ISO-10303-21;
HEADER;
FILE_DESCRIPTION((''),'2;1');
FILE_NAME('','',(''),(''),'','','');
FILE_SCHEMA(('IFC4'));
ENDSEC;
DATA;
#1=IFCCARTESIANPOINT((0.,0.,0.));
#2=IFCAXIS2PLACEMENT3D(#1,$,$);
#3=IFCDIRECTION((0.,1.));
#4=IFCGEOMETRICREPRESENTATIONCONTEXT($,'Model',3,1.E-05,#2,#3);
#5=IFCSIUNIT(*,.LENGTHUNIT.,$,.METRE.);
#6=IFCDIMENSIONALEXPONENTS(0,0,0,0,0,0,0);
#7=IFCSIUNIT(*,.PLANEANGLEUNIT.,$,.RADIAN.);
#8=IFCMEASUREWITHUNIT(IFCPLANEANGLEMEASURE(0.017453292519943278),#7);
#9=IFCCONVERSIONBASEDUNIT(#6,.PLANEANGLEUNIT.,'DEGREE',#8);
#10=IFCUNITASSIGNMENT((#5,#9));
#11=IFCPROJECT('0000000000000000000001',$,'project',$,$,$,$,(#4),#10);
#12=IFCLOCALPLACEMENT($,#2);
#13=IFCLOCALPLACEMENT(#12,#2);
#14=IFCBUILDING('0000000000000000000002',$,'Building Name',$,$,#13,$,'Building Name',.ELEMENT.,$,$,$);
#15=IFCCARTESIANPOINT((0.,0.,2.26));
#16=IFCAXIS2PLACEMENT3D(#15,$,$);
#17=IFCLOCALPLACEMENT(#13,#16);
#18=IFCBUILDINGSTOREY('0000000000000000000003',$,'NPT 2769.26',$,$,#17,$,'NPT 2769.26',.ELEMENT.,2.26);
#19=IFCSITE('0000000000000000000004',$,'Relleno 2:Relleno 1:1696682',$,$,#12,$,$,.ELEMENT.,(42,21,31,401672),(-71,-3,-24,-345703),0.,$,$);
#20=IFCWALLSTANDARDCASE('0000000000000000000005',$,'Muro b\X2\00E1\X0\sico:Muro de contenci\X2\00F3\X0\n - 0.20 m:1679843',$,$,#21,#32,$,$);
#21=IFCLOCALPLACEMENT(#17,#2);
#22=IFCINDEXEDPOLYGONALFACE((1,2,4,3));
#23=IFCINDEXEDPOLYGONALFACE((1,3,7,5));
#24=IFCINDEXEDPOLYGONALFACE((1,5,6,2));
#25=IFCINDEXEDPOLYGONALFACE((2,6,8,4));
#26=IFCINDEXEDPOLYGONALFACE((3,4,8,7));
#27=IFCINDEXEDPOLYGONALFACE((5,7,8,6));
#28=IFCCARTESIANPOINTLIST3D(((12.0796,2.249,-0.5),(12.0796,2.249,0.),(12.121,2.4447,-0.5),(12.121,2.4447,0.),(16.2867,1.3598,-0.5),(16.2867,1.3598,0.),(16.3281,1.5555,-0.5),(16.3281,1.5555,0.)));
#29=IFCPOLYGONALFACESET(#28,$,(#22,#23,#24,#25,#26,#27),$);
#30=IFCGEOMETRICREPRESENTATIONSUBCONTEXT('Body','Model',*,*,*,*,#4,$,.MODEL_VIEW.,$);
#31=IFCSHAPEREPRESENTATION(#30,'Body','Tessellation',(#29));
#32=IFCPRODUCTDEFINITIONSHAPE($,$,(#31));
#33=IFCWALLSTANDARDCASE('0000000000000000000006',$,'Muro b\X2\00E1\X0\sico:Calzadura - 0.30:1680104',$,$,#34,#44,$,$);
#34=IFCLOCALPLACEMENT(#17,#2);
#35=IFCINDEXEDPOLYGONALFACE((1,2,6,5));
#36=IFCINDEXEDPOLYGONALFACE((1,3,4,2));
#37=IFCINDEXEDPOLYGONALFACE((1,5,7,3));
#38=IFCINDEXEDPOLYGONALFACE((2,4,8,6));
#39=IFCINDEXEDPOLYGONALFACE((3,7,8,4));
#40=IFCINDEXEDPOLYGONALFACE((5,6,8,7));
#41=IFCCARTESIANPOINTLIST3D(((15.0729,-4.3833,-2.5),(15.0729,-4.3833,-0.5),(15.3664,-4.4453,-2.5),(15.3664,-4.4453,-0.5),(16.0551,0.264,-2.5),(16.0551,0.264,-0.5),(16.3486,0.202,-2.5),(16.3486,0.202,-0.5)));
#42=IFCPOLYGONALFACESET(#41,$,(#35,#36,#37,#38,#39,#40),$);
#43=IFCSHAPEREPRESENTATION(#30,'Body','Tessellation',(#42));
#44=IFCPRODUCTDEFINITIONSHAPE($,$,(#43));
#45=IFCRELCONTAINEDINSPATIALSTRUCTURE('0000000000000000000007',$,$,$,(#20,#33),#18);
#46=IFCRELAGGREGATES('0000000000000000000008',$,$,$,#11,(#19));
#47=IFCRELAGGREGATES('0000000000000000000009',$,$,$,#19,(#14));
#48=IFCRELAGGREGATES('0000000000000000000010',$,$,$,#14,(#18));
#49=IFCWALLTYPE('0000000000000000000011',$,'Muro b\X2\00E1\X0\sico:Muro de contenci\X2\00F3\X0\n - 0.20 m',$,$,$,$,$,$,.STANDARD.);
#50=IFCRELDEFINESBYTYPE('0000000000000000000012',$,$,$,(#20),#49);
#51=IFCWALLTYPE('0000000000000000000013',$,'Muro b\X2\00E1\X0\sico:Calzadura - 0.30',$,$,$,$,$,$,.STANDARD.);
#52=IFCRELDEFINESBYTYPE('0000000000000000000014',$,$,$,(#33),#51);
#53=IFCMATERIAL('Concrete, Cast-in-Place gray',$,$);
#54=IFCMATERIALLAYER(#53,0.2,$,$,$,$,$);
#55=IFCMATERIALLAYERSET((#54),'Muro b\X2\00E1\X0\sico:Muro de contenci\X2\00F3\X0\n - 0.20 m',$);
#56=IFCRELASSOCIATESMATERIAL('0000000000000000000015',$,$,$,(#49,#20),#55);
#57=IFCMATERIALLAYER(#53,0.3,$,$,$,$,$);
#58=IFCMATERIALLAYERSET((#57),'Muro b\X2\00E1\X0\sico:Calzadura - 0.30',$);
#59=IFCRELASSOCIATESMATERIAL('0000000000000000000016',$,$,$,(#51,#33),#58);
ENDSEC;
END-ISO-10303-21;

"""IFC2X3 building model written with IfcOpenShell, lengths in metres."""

from ifc_helpers import new_model, entity, si_unit, converted_unit, direction, frame, frame_2d, origin, place, context, subcontext, project, spatial, rectangle, extrude, material, layer, layer_set, layer_usage, type_object, element, save


model = new_model("IFC2X3")

# Units and contexts
model_context = context("Model", 3, precision=1e-05, world=origin(), true_north=direction((0.0, 1.0)))
body_context = subcontext(model_context, "Body", "Model", "MODEL_VIEW")
ifc_project = project(units=[si_unit("LENGTHUNIT", "METRE"), converted_unit("PLANEANGLEUNIT", "DEGREE", entity("IfcPlaneAngleMeasure", 0.017453292519943278), si_unit("PLANEANGLEUNIT", "RADIAN"), dimensions=[0, 0, 0, 0, 0, 0, 0])], contexts=[model_context])

# Site, building, storey
site_placement = place(None, origin())
site = spatial("IfcSite", under=ifc_project, at=site_placement, Name="Relleno 2:Relleno 1:1696682", CompositionType="ELEMENT", RefLatitude=(42, 21, 31, 401672), RefLongitude=(-71, -3, -24, -345703), RefElevation=0.0)
building_placement = place(site_placement, origin())
building = spatial("IfcBuilding", under=site, at=building_placement, Name="Building Name", LongName="Building Name", CompositionType="ELEMENT")
storey_placement = place(building_placement, frame((0.0, 0.0, 2.26)))
storey = spatial("IfcBuildingStorey", under=building, at=storey_placement, Name="NPT 2769.26", LongName="NPT 2769.26", CompositionType="ELEMENT", Elevation=2.26)

# Shared definitions
ifc_material = material(Name="Concrete, Cast-in-Place gray")

# Walls
ifc_layer_1 = layer(ifc_material, 0.2)
ifc_layer_set_1 = layer_set([ifc_layer_1], Name="Muro básico:Muro de contención - 0.20 m")
ifc_layer_usage_1 = layer_usage(ifc_layer_set_1, "AXIS2", "NEGATIVE", 0.1)
wall_type_1 = type_object("IfcWallType", Name="Muro básico:Muro de contención - 0.20 m", PredefinedType="STANDARD", material=ifc_layer_set_1)
wall_1_placement = place(storey_placement, frame((12.1003, 2.3468, -0.5), z_axis=(0.0, 0.0, 1.0), x_axis=(0.978388, -0.206778, 0.0)))
element("IfcWallStandardCase", 1, at=wall_1_placement, inside=storey, type_object=wall_type_1, material=ifc_layer_usage_1, Name="Muro básico:Muro de contención - 0.20 m:1679843", context=body_context, shape_type="SweptSolid", body=[
    extrude(rectangle(XDim=4.3, YDim=0.2, at=frame_2d((2.15, 0.0), x_axis=(-1.0, 0.0))), origin(), (0.0, 0.0, 1.0), 0.5),
])
ifc_layer_2 = layer(ifc_material, 0.3)
ifc_layer_set_2 = layer_set([ifc_layer_2], Name="Muro básico:Calzadura - 0.30")
ifc_layer_usage_2 = layer_usage(ifc_layer_set_2, "AXIS2", "NEGATIVE", 0.15)
wall_type_2 = type_object("IfcWallType", Name="Muro básico:Calzadura - 0.30", PredefinedType="STANDARD", material=ifc_layer_set_2)
wall_2_placement = place(storey_placement, frame((16.2019, 0.233, -2.5), z_axis=(0.0, 0.0, 1.0), x_axis=(-0.206778, -0.978388, 0.0)))
element("IfcWallStandardCase", 2, at=wall_2_placement, inside=storey, type_object=wall_type_2, material=ifc_layer_usage_2, Name="Muro básico:Calzadura - 0.30:1680104", context=body_context, shape_type="SweptSolid", body=[
    extrude(rectangle(XDim=4.75, YDim=0.3, at=frame_2d((2.375, 0.0), x_axis=(-1.0, 0.0))), origin(), (0.0, 0.0, 1.0), 2.0),
])

save(model, "model.ifc")
